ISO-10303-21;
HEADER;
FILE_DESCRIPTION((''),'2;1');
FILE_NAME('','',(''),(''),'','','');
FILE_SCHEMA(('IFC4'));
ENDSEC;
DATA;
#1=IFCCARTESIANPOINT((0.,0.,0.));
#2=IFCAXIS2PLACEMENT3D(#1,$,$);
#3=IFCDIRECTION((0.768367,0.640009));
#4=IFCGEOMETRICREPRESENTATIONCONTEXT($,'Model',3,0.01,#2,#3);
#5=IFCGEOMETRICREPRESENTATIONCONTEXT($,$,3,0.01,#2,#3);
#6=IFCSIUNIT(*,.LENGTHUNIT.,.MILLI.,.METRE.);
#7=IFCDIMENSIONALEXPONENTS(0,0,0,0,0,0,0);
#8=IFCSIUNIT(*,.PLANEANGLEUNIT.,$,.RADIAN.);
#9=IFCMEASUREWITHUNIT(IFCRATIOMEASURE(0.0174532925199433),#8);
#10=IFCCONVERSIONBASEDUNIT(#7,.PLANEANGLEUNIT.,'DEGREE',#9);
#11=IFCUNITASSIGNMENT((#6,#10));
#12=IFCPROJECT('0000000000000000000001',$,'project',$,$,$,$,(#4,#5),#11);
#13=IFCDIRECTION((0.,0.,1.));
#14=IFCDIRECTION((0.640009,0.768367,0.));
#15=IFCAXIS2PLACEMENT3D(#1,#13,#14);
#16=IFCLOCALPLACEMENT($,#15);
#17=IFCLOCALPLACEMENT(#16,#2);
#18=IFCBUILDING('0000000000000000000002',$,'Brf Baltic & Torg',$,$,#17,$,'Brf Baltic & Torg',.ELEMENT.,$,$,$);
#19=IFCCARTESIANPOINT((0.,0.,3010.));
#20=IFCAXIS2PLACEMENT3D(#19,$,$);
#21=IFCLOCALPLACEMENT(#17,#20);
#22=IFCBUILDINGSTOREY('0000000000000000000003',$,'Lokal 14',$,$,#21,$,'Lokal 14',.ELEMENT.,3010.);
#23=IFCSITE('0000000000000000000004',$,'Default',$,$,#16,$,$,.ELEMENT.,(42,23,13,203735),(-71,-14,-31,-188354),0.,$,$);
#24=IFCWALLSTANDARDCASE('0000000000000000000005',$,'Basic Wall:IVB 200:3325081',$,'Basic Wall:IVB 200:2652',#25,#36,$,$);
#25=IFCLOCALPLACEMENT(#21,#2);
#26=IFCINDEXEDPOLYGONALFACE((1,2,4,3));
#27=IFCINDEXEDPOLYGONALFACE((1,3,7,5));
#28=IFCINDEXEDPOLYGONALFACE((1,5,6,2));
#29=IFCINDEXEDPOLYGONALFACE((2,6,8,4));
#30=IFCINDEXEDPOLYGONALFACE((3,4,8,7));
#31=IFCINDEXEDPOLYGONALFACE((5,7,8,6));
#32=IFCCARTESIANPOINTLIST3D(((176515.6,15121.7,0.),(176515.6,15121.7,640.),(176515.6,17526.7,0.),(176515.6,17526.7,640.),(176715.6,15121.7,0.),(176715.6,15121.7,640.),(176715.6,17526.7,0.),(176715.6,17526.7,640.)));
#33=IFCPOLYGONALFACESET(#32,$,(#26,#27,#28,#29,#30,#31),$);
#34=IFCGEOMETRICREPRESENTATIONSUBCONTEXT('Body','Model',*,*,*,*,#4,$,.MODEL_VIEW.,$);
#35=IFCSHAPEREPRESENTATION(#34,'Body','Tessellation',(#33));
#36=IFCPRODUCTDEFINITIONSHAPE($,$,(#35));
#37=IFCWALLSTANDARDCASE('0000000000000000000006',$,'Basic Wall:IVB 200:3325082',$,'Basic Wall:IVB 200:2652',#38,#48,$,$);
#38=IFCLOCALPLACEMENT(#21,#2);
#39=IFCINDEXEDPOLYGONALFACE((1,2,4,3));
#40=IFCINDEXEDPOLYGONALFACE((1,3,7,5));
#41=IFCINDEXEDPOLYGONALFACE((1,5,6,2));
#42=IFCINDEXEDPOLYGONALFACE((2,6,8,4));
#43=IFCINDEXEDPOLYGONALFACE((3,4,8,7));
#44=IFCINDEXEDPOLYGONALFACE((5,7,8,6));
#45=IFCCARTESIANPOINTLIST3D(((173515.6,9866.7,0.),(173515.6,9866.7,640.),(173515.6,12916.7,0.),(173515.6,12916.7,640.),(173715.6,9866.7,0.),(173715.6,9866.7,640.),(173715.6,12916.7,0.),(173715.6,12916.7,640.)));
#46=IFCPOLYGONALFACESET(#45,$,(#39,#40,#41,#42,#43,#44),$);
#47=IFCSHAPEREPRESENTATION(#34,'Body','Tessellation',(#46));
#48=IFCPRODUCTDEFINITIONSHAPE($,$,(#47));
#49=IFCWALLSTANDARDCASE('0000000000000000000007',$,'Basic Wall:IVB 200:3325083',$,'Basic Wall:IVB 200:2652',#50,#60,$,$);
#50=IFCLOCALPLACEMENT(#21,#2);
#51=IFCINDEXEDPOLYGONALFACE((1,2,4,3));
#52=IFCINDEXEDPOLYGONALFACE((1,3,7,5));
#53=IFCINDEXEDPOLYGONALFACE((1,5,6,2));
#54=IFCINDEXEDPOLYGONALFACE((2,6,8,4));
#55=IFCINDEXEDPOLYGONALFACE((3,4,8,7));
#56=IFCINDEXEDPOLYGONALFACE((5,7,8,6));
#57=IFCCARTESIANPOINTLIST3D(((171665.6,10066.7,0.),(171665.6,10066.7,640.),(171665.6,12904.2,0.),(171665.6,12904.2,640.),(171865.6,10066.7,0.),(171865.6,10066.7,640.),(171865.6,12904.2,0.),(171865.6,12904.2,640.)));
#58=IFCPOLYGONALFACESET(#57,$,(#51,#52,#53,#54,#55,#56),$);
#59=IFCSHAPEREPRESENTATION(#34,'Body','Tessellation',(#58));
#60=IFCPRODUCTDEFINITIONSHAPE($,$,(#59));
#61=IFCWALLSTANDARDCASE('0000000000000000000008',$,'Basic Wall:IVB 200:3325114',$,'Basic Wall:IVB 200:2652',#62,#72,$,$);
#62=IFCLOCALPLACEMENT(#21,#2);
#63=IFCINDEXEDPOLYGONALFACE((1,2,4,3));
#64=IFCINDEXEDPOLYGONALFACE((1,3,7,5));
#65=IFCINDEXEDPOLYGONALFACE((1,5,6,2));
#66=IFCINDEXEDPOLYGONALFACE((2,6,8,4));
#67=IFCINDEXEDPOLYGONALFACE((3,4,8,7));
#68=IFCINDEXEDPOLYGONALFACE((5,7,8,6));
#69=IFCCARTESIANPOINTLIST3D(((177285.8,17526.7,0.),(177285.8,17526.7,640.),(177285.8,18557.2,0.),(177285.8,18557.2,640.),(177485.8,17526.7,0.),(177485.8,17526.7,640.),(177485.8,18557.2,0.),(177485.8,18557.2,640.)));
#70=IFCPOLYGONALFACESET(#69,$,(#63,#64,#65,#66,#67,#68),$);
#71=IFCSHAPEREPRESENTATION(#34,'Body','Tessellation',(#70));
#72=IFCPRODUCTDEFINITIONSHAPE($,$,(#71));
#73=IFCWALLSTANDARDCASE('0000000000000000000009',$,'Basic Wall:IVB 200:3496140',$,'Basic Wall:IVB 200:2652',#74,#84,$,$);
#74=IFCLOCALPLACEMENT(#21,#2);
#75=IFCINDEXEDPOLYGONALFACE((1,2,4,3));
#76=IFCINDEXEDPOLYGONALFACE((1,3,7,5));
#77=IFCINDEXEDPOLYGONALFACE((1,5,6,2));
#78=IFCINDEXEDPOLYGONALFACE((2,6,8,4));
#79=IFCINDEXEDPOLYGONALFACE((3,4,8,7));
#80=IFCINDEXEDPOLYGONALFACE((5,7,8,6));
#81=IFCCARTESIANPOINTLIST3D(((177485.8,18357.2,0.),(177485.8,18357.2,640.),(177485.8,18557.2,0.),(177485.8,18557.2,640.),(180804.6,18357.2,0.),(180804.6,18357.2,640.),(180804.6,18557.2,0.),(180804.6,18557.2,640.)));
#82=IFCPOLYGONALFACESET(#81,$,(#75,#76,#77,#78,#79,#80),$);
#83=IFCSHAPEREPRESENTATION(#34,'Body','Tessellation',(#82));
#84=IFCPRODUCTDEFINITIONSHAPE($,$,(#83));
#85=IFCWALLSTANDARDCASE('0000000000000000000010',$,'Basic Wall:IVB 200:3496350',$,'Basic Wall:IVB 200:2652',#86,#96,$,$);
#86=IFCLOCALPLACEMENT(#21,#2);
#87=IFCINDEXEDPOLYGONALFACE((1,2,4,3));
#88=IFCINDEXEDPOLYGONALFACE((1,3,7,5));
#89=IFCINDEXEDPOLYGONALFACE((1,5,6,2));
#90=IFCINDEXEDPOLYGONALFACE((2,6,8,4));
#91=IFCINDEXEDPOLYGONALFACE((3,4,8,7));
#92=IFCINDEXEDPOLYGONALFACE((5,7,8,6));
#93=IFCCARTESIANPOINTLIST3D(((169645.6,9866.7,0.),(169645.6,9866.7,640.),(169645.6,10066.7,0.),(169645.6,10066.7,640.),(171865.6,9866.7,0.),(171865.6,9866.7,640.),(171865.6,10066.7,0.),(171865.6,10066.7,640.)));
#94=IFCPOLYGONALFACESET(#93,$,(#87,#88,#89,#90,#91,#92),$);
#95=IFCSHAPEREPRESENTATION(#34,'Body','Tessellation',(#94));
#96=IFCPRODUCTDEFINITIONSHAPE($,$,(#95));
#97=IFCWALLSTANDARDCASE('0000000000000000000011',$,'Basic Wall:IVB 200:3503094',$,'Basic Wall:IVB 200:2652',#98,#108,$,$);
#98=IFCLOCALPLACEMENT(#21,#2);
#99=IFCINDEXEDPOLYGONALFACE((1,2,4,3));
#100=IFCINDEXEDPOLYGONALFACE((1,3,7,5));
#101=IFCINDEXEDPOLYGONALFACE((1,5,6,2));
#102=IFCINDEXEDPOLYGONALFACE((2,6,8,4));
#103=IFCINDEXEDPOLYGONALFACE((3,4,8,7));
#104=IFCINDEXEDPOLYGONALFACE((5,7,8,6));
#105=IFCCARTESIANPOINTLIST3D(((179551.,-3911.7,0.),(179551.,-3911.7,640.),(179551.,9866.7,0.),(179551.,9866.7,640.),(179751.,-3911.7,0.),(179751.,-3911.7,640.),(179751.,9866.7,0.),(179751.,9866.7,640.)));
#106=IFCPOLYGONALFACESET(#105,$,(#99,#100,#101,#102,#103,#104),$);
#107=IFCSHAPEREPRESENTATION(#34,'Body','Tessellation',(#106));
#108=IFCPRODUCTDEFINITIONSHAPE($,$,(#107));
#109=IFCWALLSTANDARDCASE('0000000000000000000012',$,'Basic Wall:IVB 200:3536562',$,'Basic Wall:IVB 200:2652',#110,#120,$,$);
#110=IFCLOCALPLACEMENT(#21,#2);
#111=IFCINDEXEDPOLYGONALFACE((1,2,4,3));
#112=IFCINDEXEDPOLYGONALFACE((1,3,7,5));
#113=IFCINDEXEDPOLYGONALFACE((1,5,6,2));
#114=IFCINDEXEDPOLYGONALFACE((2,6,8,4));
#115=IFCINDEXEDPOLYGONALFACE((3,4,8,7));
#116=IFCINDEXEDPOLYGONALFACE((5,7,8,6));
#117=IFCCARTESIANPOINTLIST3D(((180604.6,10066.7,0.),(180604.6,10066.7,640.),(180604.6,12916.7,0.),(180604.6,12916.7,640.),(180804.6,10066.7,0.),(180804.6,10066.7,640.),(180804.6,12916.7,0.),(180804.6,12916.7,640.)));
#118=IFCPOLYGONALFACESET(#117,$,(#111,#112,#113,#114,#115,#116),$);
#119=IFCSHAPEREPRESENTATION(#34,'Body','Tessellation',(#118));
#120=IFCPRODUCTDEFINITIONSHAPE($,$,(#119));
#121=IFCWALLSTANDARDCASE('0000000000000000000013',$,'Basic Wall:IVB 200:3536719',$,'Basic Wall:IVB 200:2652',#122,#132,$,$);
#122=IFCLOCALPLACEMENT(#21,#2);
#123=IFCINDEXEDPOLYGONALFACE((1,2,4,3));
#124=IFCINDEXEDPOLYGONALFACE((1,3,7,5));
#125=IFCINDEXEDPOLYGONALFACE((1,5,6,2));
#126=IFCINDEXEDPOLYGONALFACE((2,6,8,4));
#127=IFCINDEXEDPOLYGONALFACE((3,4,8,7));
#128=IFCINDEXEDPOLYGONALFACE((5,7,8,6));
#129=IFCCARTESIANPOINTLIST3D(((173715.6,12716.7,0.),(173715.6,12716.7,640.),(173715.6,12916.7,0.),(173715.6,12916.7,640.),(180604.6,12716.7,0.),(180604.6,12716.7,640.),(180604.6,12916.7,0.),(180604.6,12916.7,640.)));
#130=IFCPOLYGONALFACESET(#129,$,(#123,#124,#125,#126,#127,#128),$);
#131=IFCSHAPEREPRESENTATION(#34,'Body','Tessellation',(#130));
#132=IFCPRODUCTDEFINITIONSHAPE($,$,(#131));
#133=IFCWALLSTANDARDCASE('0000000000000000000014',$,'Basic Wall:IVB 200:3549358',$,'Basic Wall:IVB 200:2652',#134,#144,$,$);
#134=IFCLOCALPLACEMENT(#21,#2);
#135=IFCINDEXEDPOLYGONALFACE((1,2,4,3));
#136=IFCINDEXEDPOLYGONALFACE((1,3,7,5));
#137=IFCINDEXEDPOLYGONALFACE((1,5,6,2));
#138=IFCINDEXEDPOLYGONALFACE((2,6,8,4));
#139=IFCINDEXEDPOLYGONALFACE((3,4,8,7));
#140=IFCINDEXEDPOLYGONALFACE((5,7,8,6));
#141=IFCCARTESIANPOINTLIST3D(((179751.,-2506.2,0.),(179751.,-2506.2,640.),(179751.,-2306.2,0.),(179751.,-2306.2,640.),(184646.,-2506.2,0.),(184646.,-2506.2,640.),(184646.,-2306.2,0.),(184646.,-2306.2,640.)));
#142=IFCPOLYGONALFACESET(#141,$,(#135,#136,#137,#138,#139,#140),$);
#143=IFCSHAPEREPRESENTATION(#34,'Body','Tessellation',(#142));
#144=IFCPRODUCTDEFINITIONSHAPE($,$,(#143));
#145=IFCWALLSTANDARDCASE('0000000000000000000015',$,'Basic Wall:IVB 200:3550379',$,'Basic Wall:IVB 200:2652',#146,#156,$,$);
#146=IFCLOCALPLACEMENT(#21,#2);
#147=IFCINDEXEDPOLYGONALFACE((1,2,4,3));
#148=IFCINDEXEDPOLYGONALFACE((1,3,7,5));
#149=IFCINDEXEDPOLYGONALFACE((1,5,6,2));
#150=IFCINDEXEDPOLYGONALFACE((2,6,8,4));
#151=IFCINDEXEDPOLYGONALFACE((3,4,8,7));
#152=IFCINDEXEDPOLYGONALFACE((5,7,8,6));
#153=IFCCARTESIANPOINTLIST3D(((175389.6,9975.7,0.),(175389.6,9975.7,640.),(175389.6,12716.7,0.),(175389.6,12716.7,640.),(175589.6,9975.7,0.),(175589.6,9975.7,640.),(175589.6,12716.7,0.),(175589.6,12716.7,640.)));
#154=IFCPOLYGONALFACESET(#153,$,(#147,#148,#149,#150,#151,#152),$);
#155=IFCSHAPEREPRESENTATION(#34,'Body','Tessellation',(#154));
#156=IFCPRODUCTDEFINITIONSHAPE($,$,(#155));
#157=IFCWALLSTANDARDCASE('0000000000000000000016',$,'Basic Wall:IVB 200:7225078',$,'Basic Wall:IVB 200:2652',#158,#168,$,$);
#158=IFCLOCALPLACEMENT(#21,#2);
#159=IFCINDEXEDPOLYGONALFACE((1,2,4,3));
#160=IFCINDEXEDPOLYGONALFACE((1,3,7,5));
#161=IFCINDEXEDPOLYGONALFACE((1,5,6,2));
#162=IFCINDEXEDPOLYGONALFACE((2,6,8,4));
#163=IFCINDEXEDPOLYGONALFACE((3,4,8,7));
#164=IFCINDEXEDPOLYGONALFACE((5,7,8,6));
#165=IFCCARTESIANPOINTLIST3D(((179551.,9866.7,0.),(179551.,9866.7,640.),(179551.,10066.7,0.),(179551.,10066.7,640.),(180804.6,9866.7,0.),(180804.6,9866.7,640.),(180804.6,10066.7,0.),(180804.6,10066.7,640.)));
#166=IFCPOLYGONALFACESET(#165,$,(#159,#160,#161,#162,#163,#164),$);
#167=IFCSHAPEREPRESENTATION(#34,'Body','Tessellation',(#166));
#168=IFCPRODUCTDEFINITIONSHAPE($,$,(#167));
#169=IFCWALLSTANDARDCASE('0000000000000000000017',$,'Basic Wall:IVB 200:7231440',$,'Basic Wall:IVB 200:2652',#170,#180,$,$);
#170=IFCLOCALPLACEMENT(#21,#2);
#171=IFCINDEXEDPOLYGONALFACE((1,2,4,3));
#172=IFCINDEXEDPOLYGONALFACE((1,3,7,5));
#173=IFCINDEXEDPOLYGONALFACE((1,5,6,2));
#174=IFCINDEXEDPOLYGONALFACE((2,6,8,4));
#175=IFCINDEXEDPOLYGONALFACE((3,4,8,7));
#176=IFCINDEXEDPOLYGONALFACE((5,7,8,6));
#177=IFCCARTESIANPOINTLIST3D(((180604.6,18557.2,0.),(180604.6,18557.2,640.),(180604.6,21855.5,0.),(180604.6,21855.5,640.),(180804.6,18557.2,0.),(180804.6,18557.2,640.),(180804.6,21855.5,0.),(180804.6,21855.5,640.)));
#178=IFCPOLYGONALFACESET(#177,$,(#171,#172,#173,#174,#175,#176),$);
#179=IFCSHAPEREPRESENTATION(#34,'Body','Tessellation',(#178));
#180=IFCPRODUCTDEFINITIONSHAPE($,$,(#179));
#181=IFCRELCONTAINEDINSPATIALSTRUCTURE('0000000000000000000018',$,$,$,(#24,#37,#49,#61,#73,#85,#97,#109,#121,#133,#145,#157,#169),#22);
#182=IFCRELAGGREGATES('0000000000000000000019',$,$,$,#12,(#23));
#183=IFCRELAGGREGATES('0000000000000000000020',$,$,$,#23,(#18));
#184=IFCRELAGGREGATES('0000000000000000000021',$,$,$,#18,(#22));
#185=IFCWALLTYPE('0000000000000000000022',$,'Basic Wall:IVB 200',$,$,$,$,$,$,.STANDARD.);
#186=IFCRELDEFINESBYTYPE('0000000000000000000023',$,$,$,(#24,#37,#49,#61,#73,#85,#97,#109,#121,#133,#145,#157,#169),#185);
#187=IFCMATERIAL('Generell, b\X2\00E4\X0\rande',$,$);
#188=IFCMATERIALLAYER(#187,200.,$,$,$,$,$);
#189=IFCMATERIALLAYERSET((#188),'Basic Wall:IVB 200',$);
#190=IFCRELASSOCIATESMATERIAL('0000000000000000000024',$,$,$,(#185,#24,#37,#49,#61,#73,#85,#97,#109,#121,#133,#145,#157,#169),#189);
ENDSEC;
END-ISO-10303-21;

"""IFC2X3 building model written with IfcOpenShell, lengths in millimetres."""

from ifc_helpers import new_model, entity, si_unit, converted_unit, direction, frame, frame_2d, origin, place, context, subcontext, project, spatial, rectangle, extrude, clip, halfspace, material, layer, layer_set, layer_usage, type_object, element, save


model = new_model("IFC2X3")

# Units and contexts
model_context = context("Model", 3, precision=0.01, world=origin(), true_north=direction((0.768367, 0.640009)))
context_of_model = context(None, 3, precision=0.01, world=origin(), true_north=direction((0.768367, 0.640009)))
body_context = subcontext(model_context, "Body", "Model", "MODEL_VIEW")
ifc_project = project(units=[si_unit("LENGTHUNIT", "METRE", prefix="MILLI"), converted_unit("PLANEANGLEUNIT", "DEGREE", entity("IfcRatioMeasure", 0.0174532925199433), si_unit("PLANEANGLEUNIT", "RADIAN"), dimensions=[0, 0, 0, 0, 0, 0, 0])], contexts=[model_context, context_of_model])

# Site, building, storey
site_placement = place(None, frame((0.0, 0.0, 0.0), z_axis=(0.0, 0.0, 1.0), x_axis=(0.640009, 0.768367, 0.0)))
site = spatial("IfcSite", under=ifc_project, at=site_placement, Name="Default", CompositionType="ELEMENT", RefLatitude=(42, 23, 13, 203735), RefLongitude=(-71, -14, -31, -188354), RefElevation=0.0)
building_placement = place(site_placement, origin())
building = spatial("IfcBuilding", under=site, at=building_placement, Name="Brf Baltic & Torg", LongName="Brf Baltic & Torg", CompositionType="ELEMENT")
storey_placement = place(building_placement, frame((0.0, 0.0, 3010.0)))
storey = spatial("IfcBuildingStorey", under=building, at=storey_placement, Name="Lokal 14", LongName="Lokal 14", CompositionType="ELEMENT", Elevation=3010.0)

# Walls
ifc_material = material(Name="Generell, bärande")
ifc_layer = layer(ifc_material, 200.0)
ifc_layer_set = layer_set([ifc_layer], Name="Basic Wall:IVB 200")
ifc_layer_usage_1 = layer_usage(ifc_layer_set, "AXIS2", "NEGATIVE", 100.0)
wall_type = type_object("IfcWallType", Name="Basic Wall:IVB 200", PredefinedType="STANDARD", material=ifc_layer_set)
wall_1_placement = place(storey_placement, frame((176615.6, 15121.7, 0.0), z_axis=(0.0, 0.0, 1.0), x_axis=(0.0, 1.0, 0.0)))
element("IfcWallStandardCase", 1, at=wall_1_placement, inside=storey, type_object=wall_type, material=ifc_layer_usage_1, Name="Basic Wall:IVB 200:3325081", ObjectType="Basic Wall:IVB 200:2652", context=body_context, shape_type="Clipping", body=[
    clip(extrude(rectangle(XDim=2405.0, YDim=200.0, at=frame_2d((1202.5, 0.0), x_axis=(-1.0, 0.0))), origin(), (0.0, 0.0, 1.0), 640.0), halfspace(frame((0.0, 0.0, -1360.0)), True)),
])
ifc_layer_usage_2 = layer_usage(ifc_layer_set, "AXIS2", "NEGATIVE", 100.0)
wall_2_placement = place(storey_placement, frame((173615.6, 9866.7, 0.0), z_axis=(0.0, 0.0, 1.0), x_axis=(0.0, 1.0, 0.0)))
element("IfcWallStandardCase", 2, at=wall_2_placement, inside=storey, type_object=wall_type, material=ifc_layer_usage_2, Name="Basic Wall:IVB 200:3325082", ObjectType="Basic Wall:IVB 200:2652", context=body_context, shape_type="Clipping", body=[
    clip(extrude(rectangle(XDim=3050.0, YDim=200.0, at=frame_2d((1525.0, 0.0), x_axis=(-1.0, 0.0))), origin(), (0.0, 0.0, 1.0), 640.0), halfspace(frame((0.0, 0.0, -1360.0)), True)),
])
ifc_layer_usage_3 = layer_usage(ifc_layer_set, "AXIS2", "NEGATIVE", 100.0)
wall_3_placement = place(storey_placement, frame((171765.6, 10066.7, 0.0), z_axis=(0.0, 0.0, 1.0), x_axis=(0.0, 1.0, 0.0)))
element("IfcWallStandardCase", 3, at=wall_3_placement, inside=storey, type_object=wall_type, material=ifc_layer_usage_3, Name="Basic Wall:IVB 200:3325083", ObjectType="Basic Wall:IVB 200:2652", context=body_context, shape_type="Clipping", body=[
    clip(extrude(rectangle(XDim=2837.5, YDim=200.0, at=frame_2d((1418.8, 0.0), x_axis=(-1.0, 0.0))), origin(), (0.0, 0.0, 1.0), 640.0), halfspace(frame((0.0, 0.0, -1360.0)), True)),
])
ifc_layer_usage_4 = layer_usage(ifc_layer_set, "AXIS2", "NEGATIVE", 100.0)
wall_4_placement = place(storey_placement, frame((177385.8, 17526.7, 0.0), z_axis=(0.0, 0.0, 1.0), x_axis=(0.0, 1.0, 0.0)))
element("IfcWallStandardCase", 4, at=wall_4_placement, inside=storey, type_object=wall_type, material=ifc_layer_usage_4, Name="Basic Wall:IVB 200:3325114", ObjectType="Basic Wall:IVB 200:2652", context=body_context, shape_type="Clipping", body=[
    clip(extrude(rectangle(XDim=1030.5, YDim=200.0, at=frame_2d((515.2, 0.0), x_axis=(-1.0, 0.0))), origin(), (0.0, 0.0, 1.0), 640.0), halfspace(frame((0.0, 0.0, -1360.0)), True)),
])
ifc_layer_usage_5 = layer_usage(ifc_layer_set, "AXIS2", "NEGATIVE", 100.0)
wall_5_placement = place(storey_placement, frame((177485.8, 18457.2, 0.0)))
element("IfcWallStandardCase", 5, at=wall_5_placement, inside=storey, type_object=wall_type, material=ifc_layer_usage_5, Name="Basic Wall:IVB 200:3496140", ObjectType="Basic Wall:IVB 200:2652", context=body_context, shape_type="Clipping", body=[
    clip(extrude(rectangle(XDim=3318.8, YDim=200.0, at=frame_2d((1659.4, 0.0), x_axis=(-1.0, 0.0))), origin(), (0.0, 0.0, 1.0), 640.0), halfspace(frame((0.0, 0.0, -1360.0)), True)),
])
ifc_layer_usage_6 = layer_usage(ifc_layer_set, "AXIS2", "POSITIVE", -100.0)
wall_6_placement = place(storey_placement, frame((169645.6, 9966.7, 0.0)))
element("IfcWallStandardCase", 6, at=wall_6_placement, inside=storey, type_object=wall_type, material=ifc_layer_usage_6, Name="Basic Wall:IVB 200:3496350", ObjectType="Basic Wall:IVB 200:2652", context=body_context, shape_type="Clipping", body=[
    clip(extrude(rectangle(XDim=2220.0, YDim=200.0, at=frame_2d((1110.0, 0.0), x_axis=(-1.0, 0.0))), origin(), (0.0, 0.0, 1.0), 640.0), halfspace(frame((0.0, 0.0, -1360.0)), True)),
])
ifc_layer_usage_7 = layer_usage(ifc_layer_set, "AXIS2", "NEGATIVE", 100.0)
wall_7_placement = place(storey_placement, frame((179651.0, 9866.7, 0.0), z_axis=(0.0, 0.0, 1.0), x_axis=(0.0, -1.0, 0.0)))
element("IfcWallStandardCase", 7, at=wall_7_placement, inside=storey, type_object=wall_type, material=ifc_layer_usage_7, Name="Basic Wall:IVB 200:3503094", ObjectType="Basic Wall:IVB 200:2652", context=body_context, shape_type="Clipping", body=[
    clip(extrude(rectangle(XDim=13778.4, YDim=200.0, at=frame_2d((6889.2, 0.0), x_axis=(-1.0, 0.0))), origin(), (0.0, 0.0, 1.0), 640.0), halfspace(frame((0.0, 0.0, -1360.0)), True)),
])

# Walls
ifc_layer_usage_8 = layer_usage(ifc_layer_set, "AXIS2", "POSITIVE", -100.0)
wall_8_placement = place(storey_placement, frame((180704.6, 10066.7, 0.0), z_axis=(0.0, 0.0, 1.0), x_axis=(0.0, 1.0, 0.0)))
element("IfcWallStandardCase", 8, at=wall_8_placement, inside=storey, type_object=wall_type, material=ifc_layer_usage_8, Name="Basic Wall:IVB 200:3536562", ObjectType="Basic Wall:IVB 200:2652", context=body_context, shape_type="Clipping", body=[
    clip(extrude(rectangle(XDim=2850.0, YDim=200.0, at=frame_2d((1425.0, 0.0), x_axis=(-1.0, 0.0))), origin(), (0.0, 0.0, 1.0), 640.0), halfspace(frame((0.0, 0.0, -1360.0)), True)),
])
ifc_layer_usage_9 = layer_usage(ifc_layer_set, "AXIS2", "NEGATIVE", 100.0)
wall_9_placement = place(storey_placement, frame((173715.6, 12816.7, 0.0)))
element("IfcWallStandardCase", 9, at=wall_9_placement, inside=storey, type_object=wall_type, material=ifc_layer_usage_9, Name="Basic Wall:IVB 200:3536719", ObjectType="Basic Wall:IVB 200:2652", context=body_context, shape_type="Clipping", body=[
    clip(extrude(rectangle(XDim=6889.0, YDim=200.0, at=frame_2d((3444.5, 0.0), x_axis=(-1.0, 0.0))), origin(), (0.0, 0.0, 1.0), 640.0), halfspace(frame((0.0, 0.0, -1360.0)), True)),
])
ifc_layer_usage_10 = layer_usage(ifc_layer_set, "AXIS2", "NEGATIVE", 100.0)
wall_10_placement = place(storey_placement, frame((179751.0, -2406.2, 0.0)))
element("IfcWallStandardCase", 10, at=wall_10_placement, inside=storey, type_object=wall_type, material=ifc_layer_usage_10, Name="Basic Wall:IVB 200:3549358", ObjectType="Basic Wall:IVB 200:2652", context=body_context, shape_type="Clipping", body=[
    clip(extrude(rectangle(XDim=4895.0, YDim=200.0, at=frame_2d((2447.5, 0.0), x_axis=(-1.0, 0.0))), origin(), (0.0, 0.0, 1.0), 640.0), halfspace(frame((0.0, 0.0, -1360.0)), True)),
])
ifc_layer_usage_11 = layer_usage(ifc_layer_set, "AXIS2", "POSITIVE", -100.0)
wall_11_placement = place(storey_placement, frame((175489.6, 9975.7, 0.0), z_axis=(0.0, 0.0, 1.0), x_axis=(0.0, 1.0, 0.0)))
element("IfcWallStandardCase", 11, at=wall_11_placement, inside=storey, type_object=wall_type, material=ifc_layer_usage_11, Name="Basic Wall:IVB 200:3550379", ObjectType="Basic Wall:IVB 200:2652", context=body_context, shape_type="Clipping", body=[
    clip(extrude(rectangle(XDim=2741.0, YDim=200.0, at=frame_2d((1370.5, 0.0), x_axis=(-1.0, 0.0))), origin(), (0.0, 0.0, 1.0), 640.0), halfspace(frame((0.0, 0.0, -1360.0)), True)),
])

# Walls
ifc_layer_usage_12 = layer_usage(ifc_layer_set, "AXIS2", "NEGATIVE", 100.0)
wall_12_placement = place(storey_placement, frame((180804.6, 9966.7, 0.0), z_axis=(0.0, 0.0, 1.0), x_axis=(-1.0, 0.0, 0.0)))
element("IfcWallStandardCase", 12, at=wall_12_placement, inside=storey, type_object=wall_type, material=ifc_layer_usage_12, Name="Basic Wall:IVB 200:7225078", ObjectType="Basic Wall:IVB 200:2652", context=body_context, shape_type="Clipping", body=[
    clip(extrude(rectangle(XDim=1253.6, YDim=200.0, at=frame_2d((626.8, 0.0), x_axis=(-1.0, 0.0))), origin(), (0.0, 0.0, 1.0), 640.0), halfspace(frame((0.0, 0.0, -1360.0)), True)),
])
ifc_layer_usage_13 = layer_usage(ifc_layer_set, "AXIS2", "POSITIVE", -100.0)
wall_13_placement = place(storey_placement, frame((180704.6, 18557.2, 0.0), z_axis=(0.0, 0.0, 1.0), x_axis=(0.0, 1.0, 0.0)))
element("IfcWallStandardCase", 13, at=wall_13_placement, inside=storey, type_object=wall_type, material=ifc_layer_usage_13, Name="Basic Wall:IVB 200:7231440", ObjectType="Basic Wall:IVB 200:2652", context=body_context, shape_type="Clipping", body=[
    clip(extrude(rectangle(XDim=3298.3, YDim=200.0, at=frame_2d((1649.1, 0.0), x_axis=(-1.0, 0.0))), origin(), (0.0, 0.0, 1.0), 640.0), halfspace(frame((0.0, 0.0, -1360.0)), True)),
])

save(model, "model.ifc")
